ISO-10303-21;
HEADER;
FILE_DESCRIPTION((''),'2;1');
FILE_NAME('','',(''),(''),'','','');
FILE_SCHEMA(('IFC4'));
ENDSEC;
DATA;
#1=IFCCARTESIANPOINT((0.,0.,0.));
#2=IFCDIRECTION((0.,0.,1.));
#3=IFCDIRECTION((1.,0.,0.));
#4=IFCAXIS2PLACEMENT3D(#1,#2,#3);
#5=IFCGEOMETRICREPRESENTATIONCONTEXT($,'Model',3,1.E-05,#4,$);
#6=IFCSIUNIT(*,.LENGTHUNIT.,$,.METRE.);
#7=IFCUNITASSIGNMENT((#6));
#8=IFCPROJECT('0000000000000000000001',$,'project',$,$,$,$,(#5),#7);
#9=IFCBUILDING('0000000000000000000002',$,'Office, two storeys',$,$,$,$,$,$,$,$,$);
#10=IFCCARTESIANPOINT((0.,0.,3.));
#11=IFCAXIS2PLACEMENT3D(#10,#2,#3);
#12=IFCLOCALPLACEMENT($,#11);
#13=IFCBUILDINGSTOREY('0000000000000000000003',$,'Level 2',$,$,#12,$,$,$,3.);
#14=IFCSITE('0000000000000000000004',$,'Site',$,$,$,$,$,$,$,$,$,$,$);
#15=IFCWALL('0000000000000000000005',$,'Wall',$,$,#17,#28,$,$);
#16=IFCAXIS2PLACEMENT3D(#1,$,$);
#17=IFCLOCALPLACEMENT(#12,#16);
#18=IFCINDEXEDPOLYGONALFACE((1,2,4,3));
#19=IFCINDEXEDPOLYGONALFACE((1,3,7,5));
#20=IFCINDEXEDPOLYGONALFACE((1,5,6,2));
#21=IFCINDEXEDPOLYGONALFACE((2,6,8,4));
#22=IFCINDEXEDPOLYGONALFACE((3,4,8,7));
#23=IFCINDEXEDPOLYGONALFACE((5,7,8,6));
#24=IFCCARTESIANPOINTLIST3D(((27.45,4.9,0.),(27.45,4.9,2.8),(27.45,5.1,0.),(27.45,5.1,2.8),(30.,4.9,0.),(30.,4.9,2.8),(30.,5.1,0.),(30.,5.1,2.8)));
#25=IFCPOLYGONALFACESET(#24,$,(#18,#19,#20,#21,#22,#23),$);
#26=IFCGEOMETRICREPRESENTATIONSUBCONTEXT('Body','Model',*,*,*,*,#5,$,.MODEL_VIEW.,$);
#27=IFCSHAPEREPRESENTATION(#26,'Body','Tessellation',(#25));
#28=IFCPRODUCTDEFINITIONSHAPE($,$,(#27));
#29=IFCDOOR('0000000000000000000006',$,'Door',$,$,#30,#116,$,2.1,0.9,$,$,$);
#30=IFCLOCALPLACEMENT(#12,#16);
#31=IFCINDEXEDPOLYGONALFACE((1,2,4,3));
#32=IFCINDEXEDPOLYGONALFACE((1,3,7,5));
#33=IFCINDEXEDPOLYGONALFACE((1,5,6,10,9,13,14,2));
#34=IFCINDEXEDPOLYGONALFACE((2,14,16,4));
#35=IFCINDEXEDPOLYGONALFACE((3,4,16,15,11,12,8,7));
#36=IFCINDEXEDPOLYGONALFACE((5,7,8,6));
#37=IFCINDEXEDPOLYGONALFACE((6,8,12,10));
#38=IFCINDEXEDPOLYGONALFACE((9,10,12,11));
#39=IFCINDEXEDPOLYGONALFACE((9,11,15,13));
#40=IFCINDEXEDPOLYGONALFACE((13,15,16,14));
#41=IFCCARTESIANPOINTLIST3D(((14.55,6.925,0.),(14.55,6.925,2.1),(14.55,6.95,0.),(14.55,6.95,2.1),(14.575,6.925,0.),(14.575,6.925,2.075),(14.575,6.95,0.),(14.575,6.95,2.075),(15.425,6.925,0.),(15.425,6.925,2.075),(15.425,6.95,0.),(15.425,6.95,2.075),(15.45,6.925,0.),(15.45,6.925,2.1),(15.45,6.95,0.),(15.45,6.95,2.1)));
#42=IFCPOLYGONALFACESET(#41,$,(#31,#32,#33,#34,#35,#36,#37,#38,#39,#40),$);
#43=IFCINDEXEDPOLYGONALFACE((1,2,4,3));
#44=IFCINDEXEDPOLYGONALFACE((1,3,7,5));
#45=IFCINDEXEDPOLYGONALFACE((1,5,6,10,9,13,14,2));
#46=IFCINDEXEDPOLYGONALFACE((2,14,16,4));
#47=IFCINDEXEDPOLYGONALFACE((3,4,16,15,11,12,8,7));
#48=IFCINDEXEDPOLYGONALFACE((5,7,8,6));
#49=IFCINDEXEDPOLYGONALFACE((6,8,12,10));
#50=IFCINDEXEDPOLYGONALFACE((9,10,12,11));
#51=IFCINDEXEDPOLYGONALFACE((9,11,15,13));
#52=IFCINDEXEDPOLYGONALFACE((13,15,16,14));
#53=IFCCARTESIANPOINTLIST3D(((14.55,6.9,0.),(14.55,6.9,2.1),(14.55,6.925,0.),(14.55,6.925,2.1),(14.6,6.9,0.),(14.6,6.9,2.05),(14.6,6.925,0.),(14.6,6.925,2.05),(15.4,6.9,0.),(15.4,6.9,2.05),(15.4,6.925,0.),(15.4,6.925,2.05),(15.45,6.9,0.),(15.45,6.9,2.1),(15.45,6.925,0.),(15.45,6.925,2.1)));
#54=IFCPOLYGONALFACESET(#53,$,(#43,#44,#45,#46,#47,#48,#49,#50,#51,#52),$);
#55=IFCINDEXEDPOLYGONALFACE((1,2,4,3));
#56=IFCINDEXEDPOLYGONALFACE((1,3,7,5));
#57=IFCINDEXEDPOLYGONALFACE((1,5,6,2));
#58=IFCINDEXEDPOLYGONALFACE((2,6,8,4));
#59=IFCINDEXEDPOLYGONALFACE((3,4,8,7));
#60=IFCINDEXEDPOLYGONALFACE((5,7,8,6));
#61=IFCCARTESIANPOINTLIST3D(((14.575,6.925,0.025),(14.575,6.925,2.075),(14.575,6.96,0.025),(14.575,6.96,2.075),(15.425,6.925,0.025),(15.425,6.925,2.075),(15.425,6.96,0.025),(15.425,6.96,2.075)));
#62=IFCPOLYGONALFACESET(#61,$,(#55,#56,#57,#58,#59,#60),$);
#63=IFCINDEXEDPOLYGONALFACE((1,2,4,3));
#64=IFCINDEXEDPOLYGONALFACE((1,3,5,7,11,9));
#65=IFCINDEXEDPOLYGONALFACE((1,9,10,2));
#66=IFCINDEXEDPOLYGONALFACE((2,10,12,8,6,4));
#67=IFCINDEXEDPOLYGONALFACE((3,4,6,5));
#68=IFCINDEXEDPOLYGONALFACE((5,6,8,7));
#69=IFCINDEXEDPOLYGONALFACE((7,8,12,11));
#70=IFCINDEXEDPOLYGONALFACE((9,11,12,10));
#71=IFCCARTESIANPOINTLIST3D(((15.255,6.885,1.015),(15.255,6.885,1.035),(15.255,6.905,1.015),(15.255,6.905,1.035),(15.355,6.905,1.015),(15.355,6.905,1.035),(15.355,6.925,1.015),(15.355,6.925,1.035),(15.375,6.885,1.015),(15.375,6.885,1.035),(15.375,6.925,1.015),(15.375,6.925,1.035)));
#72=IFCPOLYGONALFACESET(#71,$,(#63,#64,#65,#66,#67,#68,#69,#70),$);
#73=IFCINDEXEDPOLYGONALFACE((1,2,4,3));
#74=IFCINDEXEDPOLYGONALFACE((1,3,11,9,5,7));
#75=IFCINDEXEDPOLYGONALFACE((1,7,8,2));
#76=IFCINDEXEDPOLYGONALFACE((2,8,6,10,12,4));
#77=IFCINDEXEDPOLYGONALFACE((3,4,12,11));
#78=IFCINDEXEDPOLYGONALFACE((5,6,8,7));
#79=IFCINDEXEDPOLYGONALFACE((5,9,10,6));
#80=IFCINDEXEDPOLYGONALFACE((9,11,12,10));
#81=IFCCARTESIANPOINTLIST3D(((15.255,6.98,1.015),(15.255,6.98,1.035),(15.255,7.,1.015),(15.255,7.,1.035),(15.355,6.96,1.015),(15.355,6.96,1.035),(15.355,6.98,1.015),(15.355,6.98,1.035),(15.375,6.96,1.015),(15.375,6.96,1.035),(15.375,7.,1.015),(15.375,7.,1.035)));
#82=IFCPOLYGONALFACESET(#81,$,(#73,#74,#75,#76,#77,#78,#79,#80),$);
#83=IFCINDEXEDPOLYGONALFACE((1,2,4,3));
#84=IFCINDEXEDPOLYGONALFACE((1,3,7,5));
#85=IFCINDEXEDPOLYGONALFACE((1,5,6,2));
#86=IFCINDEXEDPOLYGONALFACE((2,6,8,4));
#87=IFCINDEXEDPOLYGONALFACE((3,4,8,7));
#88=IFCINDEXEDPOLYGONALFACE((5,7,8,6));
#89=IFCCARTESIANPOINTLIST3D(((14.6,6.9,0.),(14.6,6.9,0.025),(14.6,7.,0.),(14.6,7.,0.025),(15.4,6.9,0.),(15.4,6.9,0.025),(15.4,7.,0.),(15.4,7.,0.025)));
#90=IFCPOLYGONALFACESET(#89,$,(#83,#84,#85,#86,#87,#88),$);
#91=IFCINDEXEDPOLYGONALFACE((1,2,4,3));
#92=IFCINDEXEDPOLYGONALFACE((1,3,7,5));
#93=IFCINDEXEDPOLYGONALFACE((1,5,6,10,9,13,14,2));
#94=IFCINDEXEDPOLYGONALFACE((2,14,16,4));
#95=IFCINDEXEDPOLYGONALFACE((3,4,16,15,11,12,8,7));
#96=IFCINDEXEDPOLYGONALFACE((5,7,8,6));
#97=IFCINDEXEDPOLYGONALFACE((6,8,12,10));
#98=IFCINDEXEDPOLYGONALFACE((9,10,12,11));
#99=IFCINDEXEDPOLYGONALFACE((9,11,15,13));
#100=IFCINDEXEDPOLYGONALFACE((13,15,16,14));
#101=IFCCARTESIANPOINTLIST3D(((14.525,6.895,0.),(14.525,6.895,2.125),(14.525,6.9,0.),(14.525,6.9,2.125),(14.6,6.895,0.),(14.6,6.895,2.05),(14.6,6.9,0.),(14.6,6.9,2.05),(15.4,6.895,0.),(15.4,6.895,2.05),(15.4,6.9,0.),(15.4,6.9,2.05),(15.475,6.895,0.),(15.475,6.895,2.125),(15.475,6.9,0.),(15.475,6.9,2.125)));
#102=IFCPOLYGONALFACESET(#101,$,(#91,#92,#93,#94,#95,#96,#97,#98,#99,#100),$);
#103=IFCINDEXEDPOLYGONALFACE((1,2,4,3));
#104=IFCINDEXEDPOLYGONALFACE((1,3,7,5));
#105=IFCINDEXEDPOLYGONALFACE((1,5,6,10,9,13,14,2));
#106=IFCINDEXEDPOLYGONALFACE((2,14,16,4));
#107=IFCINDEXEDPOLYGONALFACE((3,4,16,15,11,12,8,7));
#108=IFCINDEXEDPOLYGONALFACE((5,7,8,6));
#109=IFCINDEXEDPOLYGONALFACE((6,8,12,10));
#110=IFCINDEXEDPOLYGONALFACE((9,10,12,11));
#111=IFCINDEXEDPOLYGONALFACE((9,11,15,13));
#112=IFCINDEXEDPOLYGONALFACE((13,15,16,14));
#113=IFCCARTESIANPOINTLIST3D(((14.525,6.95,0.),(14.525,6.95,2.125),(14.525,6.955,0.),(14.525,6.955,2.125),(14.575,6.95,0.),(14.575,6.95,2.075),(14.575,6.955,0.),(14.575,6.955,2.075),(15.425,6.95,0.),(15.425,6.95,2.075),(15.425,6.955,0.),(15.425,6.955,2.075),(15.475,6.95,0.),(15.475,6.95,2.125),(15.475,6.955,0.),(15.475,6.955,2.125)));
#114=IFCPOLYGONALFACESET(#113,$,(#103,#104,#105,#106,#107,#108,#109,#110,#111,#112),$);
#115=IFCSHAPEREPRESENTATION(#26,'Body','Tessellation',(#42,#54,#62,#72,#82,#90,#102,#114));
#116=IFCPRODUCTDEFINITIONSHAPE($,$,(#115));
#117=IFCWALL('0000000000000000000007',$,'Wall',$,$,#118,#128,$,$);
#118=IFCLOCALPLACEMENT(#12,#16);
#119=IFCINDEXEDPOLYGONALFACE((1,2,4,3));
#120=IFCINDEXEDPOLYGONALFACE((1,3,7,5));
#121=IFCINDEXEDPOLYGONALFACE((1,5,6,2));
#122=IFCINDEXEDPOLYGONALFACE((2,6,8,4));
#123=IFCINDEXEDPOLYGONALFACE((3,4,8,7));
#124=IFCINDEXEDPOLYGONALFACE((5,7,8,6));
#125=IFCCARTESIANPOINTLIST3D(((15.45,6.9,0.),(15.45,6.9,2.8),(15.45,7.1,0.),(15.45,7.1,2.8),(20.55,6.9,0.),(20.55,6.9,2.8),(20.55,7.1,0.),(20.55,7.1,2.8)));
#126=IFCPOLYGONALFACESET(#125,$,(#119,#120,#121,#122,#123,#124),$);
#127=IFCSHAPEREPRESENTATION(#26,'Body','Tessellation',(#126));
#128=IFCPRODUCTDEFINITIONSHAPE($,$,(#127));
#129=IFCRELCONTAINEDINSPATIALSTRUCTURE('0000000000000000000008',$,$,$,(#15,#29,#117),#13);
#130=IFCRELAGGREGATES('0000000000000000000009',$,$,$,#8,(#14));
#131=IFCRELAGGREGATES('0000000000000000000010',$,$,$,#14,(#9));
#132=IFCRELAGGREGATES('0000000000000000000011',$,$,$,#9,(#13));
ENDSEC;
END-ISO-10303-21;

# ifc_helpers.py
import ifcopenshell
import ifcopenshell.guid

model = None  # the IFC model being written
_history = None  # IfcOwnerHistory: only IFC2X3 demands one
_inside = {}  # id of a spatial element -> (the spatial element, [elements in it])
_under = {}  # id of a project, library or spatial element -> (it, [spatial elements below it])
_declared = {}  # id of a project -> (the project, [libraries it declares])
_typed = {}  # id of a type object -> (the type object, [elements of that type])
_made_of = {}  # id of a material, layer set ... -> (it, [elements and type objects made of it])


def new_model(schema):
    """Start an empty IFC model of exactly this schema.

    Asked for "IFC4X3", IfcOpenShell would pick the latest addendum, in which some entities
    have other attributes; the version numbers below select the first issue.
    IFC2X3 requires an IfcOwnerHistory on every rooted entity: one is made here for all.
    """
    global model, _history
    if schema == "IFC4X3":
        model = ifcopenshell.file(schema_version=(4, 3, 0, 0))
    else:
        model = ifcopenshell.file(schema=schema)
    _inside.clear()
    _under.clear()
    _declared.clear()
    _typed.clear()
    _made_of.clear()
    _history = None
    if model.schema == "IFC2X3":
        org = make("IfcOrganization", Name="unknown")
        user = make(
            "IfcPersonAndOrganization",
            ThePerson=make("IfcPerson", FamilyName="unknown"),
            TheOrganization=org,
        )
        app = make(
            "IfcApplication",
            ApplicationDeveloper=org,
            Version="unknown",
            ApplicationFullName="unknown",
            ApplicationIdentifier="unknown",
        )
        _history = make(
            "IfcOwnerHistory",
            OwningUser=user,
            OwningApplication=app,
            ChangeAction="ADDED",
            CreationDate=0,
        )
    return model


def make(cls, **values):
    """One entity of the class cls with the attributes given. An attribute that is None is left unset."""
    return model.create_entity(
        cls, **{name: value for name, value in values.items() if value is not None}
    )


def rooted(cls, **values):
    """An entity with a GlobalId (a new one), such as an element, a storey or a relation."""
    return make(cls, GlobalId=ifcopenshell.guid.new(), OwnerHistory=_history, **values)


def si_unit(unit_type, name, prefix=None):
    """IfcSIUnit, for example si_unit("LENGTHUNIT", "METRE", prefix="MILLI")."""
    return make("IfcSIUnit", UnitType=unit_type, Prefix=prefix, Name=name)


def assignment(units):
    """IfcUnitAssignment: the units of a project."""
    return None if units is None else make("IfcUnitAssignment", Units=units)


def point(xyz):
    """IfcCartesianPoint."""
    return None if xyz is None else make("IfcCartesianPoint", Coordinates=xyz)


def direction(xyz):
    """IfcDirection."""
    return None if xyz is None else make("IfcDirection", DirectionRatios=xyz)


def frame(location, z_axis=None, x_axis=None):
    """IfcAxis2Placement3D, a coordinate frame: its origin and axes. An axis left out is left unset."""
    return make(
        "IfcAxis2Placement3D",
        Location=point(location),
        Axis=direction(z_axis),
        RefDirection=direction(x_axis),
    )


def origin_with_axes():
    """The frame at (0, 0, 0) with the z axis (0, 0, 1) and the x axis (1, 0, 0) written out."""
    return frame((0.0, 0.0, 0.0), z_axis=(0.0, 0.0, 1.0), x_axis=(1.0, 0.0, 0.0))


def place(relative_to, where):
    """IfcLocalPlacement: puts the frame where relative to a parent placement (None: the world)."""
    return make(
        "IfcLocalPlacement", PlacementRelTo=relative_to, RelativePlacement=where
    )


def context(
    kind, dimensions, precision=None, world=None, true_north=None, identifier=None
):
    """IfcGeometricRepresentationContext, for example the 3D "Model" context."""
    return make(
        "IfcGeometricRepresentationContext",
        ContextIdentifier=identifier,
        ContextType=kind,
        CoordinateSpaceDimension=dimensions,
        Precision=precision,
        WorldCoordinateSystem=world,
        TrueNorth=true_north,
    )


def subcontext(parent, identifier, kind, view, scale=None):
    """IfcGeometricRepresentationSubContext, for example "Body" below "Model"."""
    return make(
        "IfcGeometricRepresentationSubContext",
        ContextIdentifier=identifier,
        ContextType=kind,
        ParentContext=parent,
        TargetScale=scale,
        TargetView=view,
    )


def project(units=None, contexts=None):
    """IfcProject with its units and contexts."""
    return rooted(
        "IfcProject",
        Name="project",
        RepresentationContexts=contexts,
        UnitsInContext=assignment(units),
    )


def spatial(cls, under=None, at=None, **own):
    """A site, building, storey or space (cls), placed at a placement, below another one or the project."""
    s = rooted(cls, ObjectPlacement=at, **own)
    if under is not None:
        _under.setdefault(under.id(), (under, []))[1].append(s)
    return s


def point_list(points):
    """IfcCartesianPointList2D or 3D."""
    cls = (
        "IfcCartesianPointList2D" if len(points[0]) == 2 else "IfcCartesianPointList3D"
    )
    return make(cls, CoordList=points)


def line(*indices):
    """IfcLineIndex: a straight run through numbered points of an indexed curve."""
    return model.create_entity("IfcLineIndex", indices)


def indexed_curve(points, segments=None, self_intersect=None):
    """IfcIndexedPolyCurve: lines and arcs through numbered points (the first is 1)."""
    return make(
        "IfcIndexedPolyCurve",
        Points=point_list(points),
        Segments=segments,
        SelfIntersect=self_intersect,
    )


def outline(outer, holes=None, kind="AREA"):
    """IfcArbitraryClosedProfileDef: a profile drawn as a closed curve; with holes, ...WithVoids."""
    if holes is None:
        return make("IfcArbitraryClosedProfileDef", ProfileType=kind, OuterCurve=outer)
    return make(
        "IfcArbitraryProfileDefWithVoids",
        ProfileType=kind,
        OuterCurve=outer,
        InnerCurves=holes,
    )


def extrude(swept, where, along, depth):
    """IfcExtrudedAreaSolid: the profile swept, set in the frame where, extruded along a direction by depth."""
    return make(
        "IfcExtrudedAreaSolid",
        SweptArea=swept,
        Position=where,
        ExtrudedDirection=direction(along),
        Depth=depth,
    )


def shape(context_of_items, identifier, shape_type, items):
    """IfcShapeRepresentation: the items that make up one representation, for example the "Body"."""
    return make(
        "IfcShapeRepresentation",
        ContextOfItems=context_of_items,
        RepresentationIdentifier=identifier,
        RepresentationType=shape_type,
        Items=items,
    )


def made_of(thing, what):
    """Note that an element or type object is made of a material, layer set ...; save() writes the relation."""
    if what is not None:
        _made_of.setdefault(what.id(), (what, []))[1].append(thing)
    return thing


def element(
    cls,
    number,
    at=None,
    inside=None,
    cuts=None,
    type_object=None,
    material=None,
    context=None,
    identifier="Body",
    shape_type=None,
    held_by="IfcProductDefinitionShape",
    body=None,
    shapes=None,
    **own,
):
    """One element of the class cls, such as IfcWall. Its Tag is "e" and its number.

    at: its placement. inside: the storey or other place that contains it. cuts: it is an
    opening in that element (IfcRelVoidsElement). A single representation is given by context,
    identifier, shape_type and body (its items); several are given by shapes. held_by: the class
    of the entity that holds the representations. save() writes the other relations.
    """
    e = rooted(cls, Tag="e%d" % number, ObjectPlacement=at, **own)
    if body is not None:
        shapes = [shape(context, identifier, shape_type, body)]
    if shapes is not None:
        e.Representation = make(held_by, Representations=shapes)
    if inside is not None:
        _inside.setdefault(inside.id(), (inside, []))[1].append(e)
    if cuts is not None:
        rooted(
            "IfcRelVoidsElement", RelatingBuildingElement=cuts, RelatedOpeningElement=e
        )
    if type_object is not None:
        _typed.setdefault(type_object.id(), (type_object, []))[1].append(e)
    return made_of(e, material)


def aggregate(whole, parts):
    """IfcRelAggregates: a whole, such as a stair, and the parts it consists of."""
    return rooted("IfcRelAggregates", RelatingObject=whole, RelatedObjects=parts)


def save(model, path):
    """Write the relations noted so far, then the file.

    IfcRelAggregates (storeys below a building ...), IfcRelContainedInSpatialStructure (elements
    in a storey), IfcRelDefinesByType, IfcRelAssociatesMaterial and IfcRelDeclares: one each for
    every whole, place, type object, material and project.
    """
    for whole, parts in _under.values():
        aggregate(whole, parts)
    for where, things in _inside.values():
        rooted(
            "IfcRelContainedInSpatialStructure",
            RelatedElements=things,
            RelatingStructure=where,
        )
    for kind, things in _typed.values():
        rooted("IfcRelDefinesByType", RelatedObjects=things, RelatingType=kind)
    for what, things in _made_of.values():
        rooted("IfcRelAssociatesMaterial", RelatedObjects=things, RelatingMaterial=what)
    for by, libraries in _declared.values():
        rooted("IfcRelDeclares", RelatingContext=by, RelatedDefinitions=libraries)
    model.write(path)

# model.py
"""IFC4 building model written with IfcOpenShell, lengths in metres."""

from ifc_helpers import new_model, si_unit, frame, origin_with_axes, place, context, subcontext, project, spatial, line, indexed_curve, outline, extrude, element, save


model = new_model("IFC4")

# Units and contexts
model_context = context("Model", 3, precision=1e-05, world=origin_with_axes())
body_context = subcontext(model_context, "Body", "Model", "MODEL_VIEW")
ifc_project = project(units=[si_unit("LENGTHUNIT", "METRE")], contexts=[model_context])

# Site, building, storey
site = spatial("IfcSite", under=ifc_project, Name="Site")
building = spatial("IfcBuilding", under=site, Name="Office, two storeys")
storey_placement = place(None, frame((0.0, 0.0, 3.0), z_axis=(0.0, 0.0, 1.0), x_axis=(1.0, 0.0, 0.0)))
storey = spatial("IfcBuildingStorey", under=building, at=storey_placement, Name="Level 2", Elevation=3.0)

# Wall
wall_1_placement = place(storey_placement, frame((27.45, 5.0, 0.0), z_axis=(0.0, 0.0, 1.0), x_axis=(1.0, 0.0, 0.0)))
element("IfcWall", 1, at=wall_1_placement, inside=storey, Name="Wall", context=body_context, shape_type="SweptSolid", body=[
    extrude(outline(indexed_curve([(0.0, 0.0), (0.0, 0.2), (2.55, 0.2), (2.55, 0.0), (0.0, 0.0)], self_intersect=False)), frame((0.0, -0.1, 0.0), z_axis=(0.0, 0.0, 1.0), x_axis=(1.0, 0.0, 0.0)), (0.0, 0.0, 1.0), 2.8),
])

# Door
door_1_placement = place(storey_placement, frame((14.55, 6.9, 0.0), z_axis=(0.0, 0.0, 1.0), x_axis=(1.0, 0.0, 0.0)))
element("IfcDoor", 2, at=door_1_placement, inside=storey, Name="Door", OverallHeight=2.1, OverallWidth=0.9, context=body_context, shape_type="SweptSolid", body=[
    extrude(outline(indexed_curve([(0.0, 0.0), (0.0, 2.1), (0.9, 2.1), (0.9, 0.0), (0.875, 0.0), (0.875, 2.075), (0.025, 2.075), (0.025, 0.0)], segments=[line(1, 2, 3, 4, 5, 6, 7, 8, 1)])), frame((0.0, 0.025, 0.0), z_axis=(0.0, -1.0, 0.0), x_axis=(1.0, 0.0, 0.0)), (0.0, 0.0, -1.0), 0.025),
    extrude(outline(indexed_curve([(0.0, 0.0), (0.0, 2.1), (0.9, 2.1), (0.9, 0.0), (0.85, 0.0), (0.85, 2.05), (0.05, 2.05), (0.05, 0.0)], segments=[line(1, 2, 3, 4, 5, 6, 7, 8, 1)])), frame((0.0, 0.0, 0.0), z_axis=(0.0, -1.0, 0.0), x_axis=(1.0, 0.0, 0.0)), (0.0, 0.0, -1.0), 0.025),
    extrude(outline(indexed_curve([(0.0, 0.0), (0.85, 0.0), (0.85, 0.035), (0.0, 0.035)], segments=[line(1, 2, 3, 4, 1)])), frame((0.025, 0.025, 0.025), z_axis=(0.0, 0.0, 1.0), x_axis=(1.0, 0.0, 0.0)), (0.0, 0.0, 1.0), 2.05),
    extrude(outline(indexed_curve([(0.0, 0.0), (0.0, -0.04), (-0.12, -0.04), (-0.12, -0.02), (-0.02, -0.02), (-0.02, 0.0)], segments=[line(1, 2, 3, 4, 5, 6, 1)])), frame((0.825, 0.025, 1.015), z_axis=(0.0, 0.0, 1.0), x_axis=(1.0, 0.0, 0.0)), (0.0, 0.0, 1.0), 0.02),
    extrude(outline(indexed_curve([(0.0, 0.0), (0.0, 0.04), (-0.12, 0.04), (-0.12, 0.02), (-0.02, 0.02), (-0.02, 0.0)], segments=[line(1, 2, 3, 4, 5, 6, 1)])), frame((0.825, 0.06, 1.015), z_axis=(0.0, 0.0, 1.0), x_axis=(1.0, 0.0, 0.0)), (0.0, 0.0, 1.0), 0.02),
    extrude(outline(indexed_curve([(0.0, 0.0), (0.8, 0.0), (0.8, 0.1), (0.0, 0.1)], segments=[line(1, 2, 3, 4, 1)])), frame((0.05, 0.0, 0.0), z_axis=(0.0, 0.0, 1.0), x_axis=(1.0, 0.0, 0.0)), (0.0, 0.0, 1.0), 0.025),
    extrude(outline(indexed_curve([(0.0, 0.0), (0.0, 2.125), (0.95, 2.125), (0.95, 0.0), (0.875, 0.0), (0.875, 2.05), (0.075, 2.05), (0.075, 0.0)], segments=[line(1, 2, 3, 4, 5, 6, 7, 8, 1)])), frame((-0.025, -0.005, 0.0), z_axis=(0.0, -1.0, 0.0), x_axis=(1.0, 0.0, 0.0)), (0.0, 0.0, -1.0), 0.005),
    extrude(outline(indexed_curve([(0.0, 0.0), (0.0, 2.125), (0.95, 2.125), (0.95, 0.0), (0.9, 0.0), (0.9, 2.075), (0.05, 2.075), (0.05, 0.0)], segments=[line(1, 2, 3, 4, 5, 6, 7, 8, 1)])), frame((-0.025, 0.05, 0.0), z_axis=(0.0, -1.0, 0.0), x_axis=(1.0, 0.0, 0.0)), (0.0, 0.0, -1.0), 0.005),
])

# Wall
wall_2_placement = place(storey_placement, frame((15.45, 7.0, 0.0), z_axis=(0.0, 0.0, 1.0), x_axis=(1.0, 0.0, 0.0)))
element("IfcWall", 3, at=wall_2_placement, inside=storey, Name="Wall", context=body_context, shape_type="SweptSolid", body=[
    extrude(outline(indexed_curve([(0.0, 0.0), (0.0, 0.2), (5.1, 0.2), (5.1, 0.0), (0.0, 0.0)], self_intersect=False)), frame((0.0, -0.1, 0.0), z_axis=(0.0, 0.0, 1.0), x_axis=(1.0, 0.0, 0.0)), (0.0, 0.0, 1.0), 2.8),
])

save(model, "model.ifc")
